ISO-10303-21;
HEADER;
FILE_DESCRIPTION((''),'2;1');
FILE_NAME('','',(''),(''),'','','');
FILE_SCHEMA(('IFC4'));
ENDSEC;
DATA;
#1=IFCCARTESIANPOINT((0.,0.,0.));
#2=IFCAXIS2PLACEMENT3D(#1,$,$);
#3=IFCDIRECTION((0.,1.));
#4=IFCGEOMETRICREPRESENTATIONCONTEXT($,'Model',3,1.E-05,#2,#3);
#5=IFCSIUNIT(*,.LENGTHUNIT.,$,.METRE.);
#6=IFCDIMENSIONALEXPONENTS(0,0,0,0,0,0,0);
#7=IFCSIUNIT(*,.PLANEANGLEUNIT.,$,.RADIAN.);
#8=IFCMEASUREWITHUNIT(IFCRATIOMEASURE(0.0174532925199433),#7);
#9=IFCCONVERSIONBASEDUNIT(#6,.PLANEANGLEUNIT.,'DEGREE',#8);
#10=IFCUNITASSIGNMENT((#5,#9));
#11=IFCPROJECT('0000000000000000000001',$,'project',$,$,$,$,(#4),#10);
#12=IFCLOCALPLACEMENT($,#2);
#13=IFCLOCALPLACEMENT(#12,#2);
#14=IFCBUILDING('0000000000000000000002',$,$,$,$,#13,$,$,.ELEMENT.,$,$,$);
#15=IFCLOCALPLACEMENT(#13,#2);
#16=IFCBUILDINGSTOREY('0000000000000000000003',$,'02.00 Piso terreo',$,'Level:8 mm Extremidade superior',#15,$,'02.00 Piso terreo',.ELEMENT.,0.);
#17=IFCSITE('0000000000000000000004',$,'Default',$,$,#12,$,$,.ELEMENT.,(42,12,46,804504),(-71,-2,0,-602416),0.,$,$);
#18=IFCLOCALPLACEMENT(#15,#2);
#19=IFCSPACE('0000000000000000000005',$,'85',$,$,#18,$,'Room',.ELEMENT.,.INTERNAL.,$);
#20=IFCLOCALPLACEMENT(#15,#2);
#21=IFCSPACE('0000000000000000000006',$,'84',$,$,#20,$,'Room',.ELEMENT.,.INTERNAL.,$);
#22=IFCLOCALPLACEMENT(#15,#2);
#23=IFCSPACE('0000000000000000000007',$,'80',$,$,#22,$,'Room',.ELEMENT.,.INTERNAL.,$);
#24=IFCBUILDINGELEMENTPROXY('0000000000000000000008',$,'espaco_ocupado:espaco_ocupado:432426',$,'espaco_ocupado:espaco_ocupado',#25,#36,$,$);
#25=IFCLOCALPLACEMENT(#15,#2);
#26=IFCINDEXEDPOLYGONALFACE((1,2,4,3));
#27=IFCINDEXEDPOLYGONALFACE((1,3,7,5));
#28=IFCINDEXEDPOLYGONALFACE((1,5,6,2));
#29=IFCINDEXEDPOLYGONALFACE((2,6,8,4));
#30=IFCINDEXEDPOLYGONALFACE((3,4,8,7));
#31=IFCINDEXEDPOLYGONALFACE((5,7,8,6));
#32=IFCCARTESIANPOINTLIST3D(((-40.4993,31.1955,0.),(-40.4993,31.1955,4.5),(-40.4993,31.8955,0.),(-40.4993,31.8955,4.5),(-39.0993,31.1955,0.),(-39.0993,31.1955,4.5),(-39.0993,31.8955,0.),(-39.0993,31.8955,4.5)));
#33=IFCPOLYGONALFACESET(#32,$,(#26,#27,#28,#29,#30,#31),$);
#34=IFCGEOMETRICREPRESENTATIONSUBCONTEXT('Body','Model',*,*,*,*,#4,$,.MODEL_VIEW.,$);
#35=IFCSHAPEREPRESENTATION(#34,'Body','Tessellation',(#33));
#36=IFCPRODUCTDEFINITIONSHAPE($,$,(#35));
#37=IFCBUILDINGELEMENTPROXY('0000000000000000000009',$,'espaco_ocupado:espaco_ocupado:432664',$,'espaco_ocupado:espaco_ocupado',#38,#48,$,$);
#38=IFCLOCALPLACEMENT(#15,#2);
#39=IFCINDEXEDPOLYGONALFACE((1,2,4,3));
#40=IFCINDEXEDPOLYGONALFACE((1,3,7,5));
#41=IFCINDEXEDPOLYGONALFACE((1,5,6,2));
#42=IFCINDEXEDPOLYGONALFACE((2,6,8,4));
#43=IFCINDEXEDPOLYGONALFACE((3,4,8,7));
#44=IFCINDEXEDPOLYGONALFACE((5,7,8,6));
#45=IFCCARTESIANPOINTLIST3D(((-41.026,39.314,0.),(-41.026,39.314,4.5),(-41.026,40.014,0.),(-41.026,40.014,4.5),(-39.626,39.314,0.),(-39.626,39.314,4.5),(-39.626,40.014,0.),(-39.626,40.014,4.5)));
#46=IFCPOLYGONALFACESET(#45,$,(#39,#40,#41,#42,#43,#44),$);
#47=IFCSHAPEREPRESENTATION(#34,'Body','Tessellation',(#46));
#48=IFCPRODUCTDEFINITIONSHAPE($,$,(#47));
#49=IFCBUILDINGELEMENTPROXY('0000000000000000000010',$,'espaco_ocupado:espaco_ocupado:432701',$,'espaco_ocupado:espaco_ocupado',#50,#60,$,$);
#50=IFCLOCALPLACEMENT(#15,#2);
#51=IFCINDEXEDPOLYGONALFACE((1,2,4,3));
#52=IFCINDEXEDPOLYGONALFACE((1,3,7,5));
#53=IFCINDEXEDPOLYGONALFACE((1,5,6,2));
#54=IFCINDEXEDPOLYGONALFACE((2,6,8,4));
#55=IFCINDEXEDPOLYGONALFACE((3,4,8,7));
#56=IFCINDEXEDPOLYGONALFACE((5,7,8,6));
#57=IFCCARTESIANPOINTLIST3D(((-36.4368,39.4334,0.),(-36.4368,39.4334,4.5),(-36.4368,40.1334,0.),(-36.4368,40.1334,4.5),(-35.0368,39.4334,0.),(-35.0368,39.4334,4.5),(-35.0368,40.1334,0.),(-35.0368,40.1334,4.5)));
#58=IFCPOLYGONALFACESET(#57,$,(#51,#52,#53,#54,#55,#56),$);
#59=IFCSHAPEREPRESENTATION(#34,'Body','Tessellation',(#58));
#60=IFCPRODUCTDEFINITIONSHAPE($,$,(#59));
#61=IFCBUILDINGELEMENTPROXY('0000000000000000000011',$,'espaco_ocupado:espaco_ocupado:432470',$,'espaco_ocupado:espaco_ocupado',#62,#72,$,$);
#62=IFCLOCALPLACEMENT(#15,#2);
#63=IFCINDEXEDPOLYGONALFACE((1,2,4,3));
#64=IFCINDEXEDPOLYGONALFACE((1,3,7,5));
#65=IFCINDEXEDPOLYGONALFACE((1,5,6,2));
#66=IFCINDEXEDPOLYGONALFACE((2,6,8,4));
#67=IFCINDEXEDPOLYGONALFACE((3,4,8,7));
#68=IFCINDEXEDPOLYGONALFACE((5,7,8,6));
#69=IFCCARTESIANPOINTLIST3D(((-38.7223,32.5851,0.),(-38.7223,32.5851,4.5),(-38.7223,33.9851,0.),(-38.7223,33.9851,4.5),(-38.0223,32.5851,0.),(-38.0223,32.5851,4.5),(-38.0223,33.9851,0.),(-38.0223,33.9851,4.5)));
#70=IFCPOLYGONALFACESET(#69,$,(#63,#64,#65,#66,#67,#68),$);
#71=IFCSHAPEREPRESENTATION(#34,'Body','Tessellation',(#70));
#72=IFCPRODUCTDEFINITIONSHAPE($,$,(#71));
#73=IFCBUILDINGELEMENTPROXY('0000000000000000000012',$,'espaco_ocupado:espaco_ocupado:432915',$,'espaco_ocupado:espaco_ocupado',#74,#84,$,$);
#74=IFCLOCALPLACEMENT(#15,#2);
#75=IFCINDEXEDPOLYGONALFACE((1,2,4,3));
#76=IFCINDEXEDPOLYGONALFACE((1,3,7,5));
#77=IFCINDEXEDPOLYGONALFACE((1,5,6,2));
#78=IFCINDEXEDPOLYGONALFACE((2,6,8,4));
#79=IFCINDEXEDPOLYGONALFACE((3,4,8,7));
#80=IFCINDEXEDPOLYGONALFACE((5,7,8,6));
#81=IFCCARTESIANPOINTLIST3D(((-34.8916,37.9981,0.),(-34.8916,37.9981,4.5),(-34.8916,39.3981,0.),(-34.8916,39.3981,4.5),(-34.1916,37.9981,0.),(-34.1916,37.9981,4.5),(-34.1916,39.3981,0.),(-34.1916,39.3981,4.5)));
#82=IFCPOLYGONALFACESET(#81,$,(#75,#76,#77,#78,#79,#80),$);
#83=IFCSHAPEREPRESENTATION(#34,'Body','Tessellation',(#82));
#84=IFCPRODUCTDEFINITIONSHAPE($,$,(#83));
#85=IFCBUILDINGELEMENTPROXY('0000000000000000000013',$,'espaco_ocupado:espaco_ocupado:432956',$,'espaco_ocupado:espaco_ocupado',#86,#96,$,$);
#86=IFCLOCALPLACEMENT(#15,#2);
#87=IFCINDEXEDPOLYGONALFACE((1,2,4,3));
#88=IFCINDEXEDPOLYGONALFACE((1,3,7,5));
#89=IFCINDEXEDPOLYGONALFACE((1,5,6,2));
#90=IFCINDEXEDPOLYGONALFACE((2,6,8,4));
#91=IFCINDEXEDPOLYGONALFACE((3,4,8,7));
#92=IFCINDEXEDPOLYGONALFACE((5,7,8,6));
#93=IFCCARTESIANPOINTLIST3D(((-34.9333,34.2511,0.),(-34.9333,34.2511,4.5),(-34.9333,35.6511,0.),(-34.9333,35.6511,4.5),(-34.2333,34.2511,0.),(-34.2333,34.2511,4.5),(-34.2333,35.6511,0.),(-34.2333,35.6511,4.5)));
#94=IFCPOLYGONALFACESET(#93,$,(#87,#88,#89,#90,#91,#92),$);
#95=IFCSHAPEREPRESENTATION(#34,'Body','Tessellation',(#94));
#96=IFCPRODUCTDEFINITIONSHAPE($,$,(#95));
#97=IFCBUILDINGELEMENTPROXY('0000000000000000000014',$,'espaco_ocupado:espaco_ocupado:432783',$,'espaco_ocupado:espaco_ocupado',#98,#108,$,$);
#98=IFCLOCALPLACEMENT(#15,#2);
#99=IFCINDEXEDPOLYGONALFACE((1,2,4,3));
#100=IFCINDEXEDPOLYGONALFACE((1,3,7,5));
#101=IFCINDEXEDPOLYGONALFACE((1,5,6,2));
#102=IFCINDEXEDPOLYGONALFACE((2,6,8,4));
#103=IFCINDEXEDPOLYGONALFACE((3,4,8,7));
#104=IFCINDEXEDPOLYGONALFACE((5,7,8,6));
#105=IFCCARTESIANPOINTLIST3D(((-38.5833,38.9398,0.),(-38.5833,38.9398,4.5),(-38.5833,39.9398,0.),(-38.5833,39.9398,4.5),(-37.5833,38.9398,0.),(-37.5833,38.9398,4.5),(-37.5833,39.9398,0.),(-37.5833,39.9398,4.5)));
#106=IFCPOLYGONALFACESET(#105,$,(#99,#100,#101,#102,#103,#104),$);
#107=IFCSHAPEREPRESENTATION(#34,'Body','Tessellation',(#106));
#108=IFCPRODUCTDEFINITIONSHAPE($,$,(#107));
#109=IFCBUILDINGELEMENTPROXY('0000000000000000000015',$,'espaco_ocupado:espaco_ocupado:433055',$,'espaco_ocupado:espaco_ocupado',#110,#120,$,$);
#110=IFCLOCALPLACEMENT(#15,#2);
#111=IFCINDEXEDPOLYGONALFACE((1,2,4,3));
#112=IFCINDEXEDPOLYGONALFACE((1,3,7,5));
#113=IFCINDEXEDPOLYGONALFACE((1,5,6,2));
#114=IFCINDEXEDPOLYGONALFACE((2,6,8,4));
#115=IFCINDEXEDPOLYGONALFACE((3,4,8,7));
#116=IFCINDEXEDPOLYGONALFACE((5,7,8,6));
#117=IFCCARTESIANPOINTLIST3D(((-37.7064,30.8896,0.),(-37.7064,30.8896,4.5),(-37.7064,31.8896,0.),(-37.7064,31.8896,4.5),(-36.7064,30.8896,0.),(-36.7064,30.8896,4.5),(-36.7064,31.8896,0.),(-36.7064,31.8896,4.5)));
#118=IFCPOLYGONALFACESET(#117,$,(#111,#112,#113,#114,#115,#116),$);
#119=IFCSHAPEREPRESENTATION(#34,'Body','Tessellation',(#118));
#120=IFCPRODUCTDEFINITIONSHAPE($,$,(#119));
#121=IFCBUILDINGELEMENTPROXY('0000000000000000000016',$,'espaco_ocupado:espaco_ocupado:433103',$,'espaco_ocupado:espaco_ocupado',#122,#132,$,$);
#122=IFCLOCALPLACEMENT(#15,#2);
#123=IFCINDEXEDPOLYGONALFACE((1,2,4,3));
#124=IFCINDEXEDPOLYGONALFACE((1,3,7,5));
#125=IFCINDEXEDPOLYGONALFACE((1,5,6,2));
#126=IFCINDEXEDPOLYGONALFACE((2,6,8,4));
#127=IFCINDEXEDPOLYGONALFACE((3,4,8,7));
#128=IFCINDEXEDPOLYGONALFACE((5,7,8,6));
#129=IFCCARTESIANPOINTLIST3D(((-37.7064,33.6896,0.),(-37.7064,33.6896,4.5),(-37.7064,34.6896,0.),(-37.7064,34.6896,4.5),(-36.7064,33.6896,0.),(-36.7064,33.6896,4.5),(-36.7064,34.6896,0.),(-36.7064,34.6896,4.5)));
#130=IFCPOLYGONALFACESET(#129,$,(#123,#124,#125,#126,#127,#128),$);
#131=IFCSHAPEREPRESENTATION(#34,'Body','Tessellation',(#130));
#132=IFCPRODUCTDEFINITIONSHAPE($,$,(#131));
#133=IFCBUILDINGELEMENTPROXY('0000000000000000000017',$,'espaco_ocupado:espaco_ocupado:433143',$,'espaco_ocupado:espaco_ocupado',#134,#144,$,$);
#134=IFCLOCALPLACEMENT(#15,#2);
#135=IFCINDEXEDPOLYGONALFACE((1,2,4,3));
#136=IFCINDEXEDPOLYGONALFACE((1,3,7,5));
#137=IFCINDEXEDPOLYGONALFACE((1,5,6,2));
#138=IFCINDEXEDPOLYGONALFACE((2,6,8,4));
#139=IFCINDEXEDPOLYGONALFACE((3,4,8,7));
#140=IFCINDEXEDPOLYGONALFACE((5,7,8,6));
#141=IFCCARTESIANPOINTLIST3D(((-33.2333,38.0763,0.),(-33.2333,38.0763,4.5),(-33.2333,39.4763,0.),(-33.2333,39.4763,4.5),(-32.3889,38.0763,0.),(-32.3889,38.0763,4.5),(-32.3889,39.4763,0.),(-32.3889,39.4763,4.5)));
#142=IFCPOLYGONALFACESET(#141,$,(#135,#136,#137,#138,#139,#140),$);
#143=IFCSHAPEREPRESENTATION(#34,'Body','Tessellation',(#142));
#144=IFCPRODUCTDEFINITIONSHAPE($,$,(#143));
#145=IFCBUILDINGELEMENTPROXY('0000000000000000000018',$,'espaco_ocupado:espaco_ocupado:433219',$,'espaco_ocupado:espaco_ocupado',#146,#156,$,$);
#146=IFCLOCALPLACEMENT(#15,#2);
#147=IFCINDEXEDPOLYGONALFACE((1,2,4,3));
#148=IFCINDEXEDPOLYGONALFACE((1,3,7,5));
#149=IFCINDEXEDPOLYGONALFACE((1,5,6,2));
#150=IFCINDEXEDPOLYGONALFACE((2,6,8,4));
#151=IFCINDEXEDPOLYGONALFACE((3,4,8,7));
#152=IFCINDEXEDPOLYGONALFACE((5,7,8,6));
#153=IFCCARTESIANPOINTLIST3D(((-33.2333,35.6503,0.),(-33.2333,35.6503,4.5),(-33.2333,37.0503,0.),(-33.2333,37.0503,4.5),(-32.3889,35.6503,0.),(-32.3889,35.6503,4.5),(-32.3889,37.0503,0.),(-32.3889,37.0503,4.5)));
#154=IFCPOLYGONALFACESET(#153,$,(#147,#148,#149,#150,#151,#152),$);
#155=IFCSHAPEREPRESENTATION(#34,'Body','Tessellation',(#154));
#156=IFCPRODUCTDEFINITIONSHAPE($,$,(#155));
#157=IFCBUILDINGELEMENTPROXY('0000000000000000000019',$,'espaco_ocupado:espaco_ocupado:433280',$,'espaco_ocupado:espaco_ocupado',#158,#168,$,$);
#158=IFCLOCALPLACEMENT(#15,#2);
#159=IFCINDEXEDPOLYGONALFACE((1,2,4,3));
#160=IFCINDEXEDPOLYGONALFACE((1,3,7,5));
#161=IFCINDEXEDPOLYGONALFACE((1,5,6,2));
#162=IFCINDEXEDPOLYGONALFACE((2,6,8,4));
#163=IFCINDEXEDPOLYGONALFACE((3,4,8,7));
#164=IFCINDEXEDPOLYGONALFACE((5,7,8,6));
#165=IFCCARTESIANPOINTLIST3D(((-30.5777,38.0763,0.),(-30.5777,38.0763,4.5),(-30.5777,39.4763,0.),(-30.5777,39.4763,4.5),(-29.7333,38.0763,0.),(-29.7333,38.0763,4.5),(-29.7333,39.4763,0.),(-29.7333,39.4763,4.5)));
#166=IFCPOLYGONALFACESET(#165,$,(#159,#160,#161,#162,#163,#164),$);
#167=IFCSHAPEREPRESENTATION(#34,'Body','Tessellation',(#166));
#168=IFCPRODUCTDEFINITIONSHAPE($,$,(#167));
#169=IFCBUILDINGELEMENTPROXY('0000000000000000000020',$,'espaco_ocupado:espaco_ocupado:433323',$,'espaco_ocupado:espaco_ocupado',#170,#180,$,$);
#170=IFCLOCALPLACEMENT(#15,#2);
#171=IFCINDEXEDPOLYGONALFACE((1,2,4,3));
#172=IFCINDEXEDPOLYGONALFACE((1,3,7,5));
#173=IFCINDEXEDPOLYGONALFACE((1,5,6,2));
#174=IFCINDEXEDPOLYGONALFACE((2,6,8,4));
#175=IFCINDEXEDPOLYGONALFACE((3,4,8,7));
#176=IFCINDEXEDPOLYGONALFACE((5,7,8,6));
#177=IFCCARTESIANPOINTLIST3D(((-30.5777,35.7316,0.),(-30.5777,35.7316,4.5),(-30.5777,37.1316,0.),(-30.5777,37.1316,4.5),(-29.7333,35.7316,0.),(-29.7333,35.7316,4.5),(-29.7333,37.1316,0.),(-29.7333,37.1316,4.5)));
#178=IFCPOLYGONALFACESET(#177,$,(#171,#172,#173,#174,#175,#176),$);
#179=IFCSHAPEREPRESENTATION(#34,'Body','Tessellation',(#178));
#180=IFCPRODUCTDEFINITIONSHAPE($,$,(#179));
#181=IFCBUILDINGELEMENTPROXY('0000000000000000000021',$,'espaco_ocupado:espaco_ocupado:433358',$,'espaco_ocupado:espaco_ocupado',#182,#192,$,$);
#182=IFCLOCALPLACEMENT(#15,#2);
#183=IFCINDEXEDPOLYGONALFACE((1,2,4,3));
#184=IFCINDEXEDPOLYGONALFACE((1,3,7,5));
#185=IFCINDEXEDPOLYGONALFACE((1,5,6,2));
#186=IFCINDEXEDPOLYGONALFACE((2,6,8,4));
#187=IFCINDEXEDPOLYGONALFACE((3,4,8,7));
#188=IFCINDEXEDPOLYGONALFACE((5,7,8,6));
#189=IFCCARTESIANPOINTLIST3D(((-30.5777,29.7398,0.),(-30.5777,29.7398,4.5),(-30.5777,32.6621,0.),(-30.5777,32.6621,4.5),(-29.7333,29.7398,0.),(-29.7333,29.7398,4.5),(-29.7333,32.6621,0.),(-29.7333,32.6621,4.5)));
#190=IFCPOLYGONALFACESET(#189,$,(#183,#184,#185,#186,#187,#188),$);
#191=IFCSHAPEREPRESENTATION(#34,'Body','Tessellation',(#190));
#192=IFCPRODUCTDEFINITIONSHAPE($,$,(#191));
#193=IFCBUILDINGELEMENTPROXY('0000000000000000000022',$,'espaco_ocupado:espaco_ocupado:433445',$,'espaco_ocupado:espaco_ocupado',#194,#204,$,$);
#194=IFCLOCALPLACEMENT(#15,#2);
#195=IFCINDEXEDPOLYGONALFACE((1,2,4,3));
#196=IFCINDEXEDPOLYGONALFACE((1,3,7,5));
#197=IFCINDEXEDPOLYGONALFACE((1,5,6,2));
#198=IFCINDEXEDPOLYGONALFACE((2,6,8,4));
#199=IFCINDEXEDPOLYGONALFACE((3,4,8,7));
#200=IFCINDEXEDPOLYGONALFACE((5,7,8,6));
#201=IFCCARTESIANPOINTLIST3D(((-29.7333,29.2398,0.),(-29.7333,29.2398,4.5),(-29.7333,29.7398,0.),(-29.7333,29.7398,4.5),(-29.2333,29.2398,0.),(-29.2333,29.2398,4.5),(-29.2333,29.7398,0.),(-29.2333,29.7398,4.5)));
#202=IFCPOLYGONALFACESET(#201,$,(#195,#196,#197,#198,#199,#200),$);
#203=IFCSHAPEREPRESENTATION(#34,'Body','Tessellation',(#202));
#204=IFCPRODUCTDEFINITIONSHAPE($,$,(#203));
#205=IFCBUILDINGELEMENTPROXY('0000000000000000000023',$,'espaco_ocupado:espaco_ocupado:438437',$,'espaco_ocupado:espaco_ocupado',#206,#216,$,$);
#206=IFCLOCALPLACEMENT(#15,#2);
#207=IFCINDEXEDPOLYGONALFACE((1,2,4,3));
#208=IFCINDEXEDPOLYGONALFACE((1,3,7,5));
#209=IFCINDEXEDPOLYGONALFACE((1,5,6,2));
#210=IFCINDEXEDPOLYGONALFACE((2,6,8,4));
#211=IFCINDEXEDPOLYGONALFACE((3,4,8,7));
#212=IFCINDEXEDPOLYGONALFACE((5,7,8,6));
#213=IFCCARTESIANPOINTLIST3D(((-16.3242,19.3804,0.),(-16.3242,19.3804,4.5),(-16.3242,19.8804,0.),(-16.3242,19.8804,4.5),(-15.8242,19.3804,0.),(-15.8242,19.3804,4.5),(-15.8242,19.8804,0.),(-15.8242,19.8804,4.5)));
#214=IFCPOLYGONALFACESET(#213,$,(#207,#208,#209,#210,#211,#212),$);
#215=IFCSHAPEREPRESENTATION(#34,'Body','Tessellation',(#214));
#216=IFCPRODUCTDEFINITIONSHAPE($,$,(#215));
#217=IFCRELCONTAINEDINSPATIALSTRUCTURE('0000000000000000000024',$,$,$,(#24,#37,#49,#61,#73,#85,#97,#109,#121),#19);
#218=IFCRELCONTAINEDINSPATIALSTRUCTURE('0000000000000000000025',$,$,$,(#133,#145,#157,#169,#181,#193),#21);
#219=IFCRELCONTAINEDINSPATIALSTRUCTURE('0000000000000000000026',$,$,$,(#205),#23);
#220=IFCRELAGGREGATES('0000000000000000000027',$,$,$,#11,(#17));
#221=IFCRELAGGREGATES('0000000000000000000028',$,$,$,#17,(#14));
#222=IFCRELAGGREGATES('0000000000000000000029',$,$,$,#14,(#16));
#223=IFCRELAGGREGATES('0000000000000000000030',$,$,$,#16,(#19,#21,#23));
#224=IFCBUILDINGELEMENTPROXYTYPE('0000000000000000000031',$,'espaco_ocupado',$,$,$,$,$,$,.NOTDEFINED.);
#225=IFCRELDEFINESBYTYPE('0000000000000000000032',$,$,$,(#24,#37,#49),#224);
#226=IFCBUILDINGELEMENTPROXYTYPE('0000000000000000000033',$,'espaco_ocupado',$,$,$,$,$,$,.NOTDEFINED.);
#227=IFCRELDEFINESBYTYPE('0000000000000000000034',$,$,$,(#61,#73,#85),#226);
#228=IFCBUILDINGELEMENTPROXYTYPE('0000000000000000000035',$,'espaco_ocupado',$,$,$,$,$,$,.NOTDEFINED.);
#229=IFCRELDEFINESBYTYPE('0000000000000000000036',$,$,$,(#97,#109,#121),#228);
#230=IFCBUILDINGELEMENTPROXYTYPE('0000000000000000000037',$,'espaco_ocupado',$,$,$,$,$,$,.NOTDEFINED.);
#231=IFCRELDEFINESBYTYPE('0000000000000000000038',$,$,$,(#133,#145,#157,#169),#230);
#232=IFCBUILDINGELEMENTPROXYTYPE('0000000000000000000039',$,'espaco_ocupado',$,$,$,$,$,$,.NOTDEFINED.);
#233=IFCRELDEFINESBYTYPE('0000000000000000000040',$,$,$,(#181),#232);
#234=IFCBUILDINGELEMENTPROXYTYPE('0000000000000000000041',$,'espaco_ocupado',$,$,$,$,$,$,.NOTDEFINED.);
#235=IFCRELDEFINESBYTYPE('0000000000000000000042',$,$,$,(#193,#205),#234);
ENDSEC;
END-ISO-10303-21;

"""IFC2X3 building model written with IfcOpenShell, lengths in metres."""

from ifc_helpers import new_model, entity, si_unit, converted_unit, direction, frame, origin, origin_2d_with_axis, place, context, subcontext, project, spatial, rectangle, extrude, source, transform, mapped, type_object, type_shapes, element, save


model = new_model("IFC2X3")

# Units and contexts
model_context = context("Model", 3, precision=1e-05, world=origin(), true_north=direction((0.0, 1.0)))
body_context = subcontext(model_context, "Body", "Model", "MODEL_VIEW")
ifc_project = project(units=[si_unit("LENGTHUNIT", "METRE"), converted_unit("PLANEANGLEUNIT", "DEGREE", entity("IfcRatioMeasure", 0.0174532925199433), si_unit("PLANEANGLEUNIT", "RADIAN"), dimensions=[0, 0, 0, 0, 0, 0, 0])], contexts=[model_context])

# Site, building, storey, space
site_placement = place(None, origin())
site = spatial("IfcSite", under=ifc_project, at=site_placement, Name="Default", CompositionType="ELEMENT", RefLatitude=(42, 12, 46, 804504), RefLongitude=(-71, -2, 0, -602416), RefElevation=0.0)
building_placement = place(site_placement, origin())
building = spatial("IfcBuilding", under=site, at=building_placement, CompositionType="ELEMENT")
storey_placement = place(building_placement, origin())
storey = spatial("IfcBuildingStorey", under=building, at=storey_placement, Name="02.00 Piso terreo", ObjectType="Level:8 mm Extremidade superior", LongName="02.00 Piso terreo", CompositionType="ELEMENT", Elevation=0.0)
space_1_placement = place(storey_placement, origin())
space_1 = spatial("IfcSpace", under=storey, at=space_1_placement, Name="85", LongName="Room", CompositionType="ELEMENT", InteriorOrExteriorSpace="INTERNAL")

# Building element proxies
building_element_proxy_type_1 = type_object("IfcBuildingElementProxyType", Name="espaco_ocupado", PredefinedType="NOTDEFINED")
shared_shape_1 = source(origin(), body_context, "Body", "SweptSolid", [
    extrude(rectangle(XDim=1.4, YDim=0.7, at=origin_2d_with_axis()), frame((0.0, 0.0, 0.0), z_axis=(0.0, 0.0, 1.0), x_axis=(-1.0, 0.0, 0.0)), (0.0, 0.0, 1.0), 4.5),
])
type_shapes(building_element_proxy_type_1, [shared_shape_1])
for number, where, name in (
    (1, (-39.7993, 31.5455, 0.0), "espaco_ocupado:espaco_ocupado:432426"),
    (2, (-40.326, 39.664, 0.0), "espaco_ocupado:espaco_ocupado:432664"),
    (3, (-35.7368, 39.7834, 0.0), "espaco_ocupado:espaco_ocupado:432701"),
):
    element("IfcBuildingElementProxy", number, at=place(space_1_placement, frame(where)), inside=space_1, type_object=building_element_proxy_type_1, Name=name, ObjectType="espaco_ocupado:espaco_ocupado", context=body_context, shape_type="MappedRepresentation", body=[
        mapped(shared_shape_1, transform((0.0, 0.0, 0.0), scale=1.0)),
    ])
building_element_proxy_type_2 = type_object("IfcBuildingElementProxyType", Name="espaco_ocupado", PredefinedType="NOTDEFINED")
shared_shape_2 = source(origin(), body_context, "Body", "SweptSolid", [
    extrude(rectangle(XDim=0.7, YDim=1.4, at=origin_2d_with_axis()), frame((0.0, 0.0, 0.0), z_axis=(0.0, 0.0, 1.0), x_axis=(-1.0, 0.0, 0.0)), (0.0, 0.0, 1.0), 4.5),
])
type_shapes(building_element_proxy_type_2, [shared_shape_2])
for number, where, name in (
    (4, (-38.3723, 33.2851, 0.0), "espaco_ocupado:espaco_ocupado:432470"),
    (5, (-34.5416, 38.6981, 0.0), "espaco_ocupado:espaco_ocupado:432915"),
    (6, (-34.5833, 34.9511, 0.0), "espaco_ocupado:espaco_ocupado:432956"),
):
    element("IfcBuildingElementProxy", number, at=place(space_1_placement, frame(where)), inside=space_1, type_object=building_element_proxy_type_2, Name=name, ObjectType="espaco_ocupado:espaco_ocupado", context=body_context, shape_type="MappedRepresentation", body=[
        mapped(shared_shape_2, transform((0.0, 0.0, 0.0), scale=1.0)),
    ])
building_element_proxy_type_3 = type_object("IfcBuildingElementProxyType", Name="espaco_ocupado", PredefinedType="NOTDEFINED")
shared_shape_3 = source(origin(), body_context, "Body", "SweptSolid", [
    extrude(rectangle(XDim=1.0, YDim=1.0, at=origin_2d_with_axis()), frame((0.0, 0.0, 0.0), z_axis=(0.0, 0.0, 1.0), x_axis=(-1.0, 0.0, 0.0)), (0.0, 0.0, 1.0), 4.5),
])
type_shapes(building_element_proxy_type_3, [shared_shape_3])
for number, where, name in (
    (7, (-38.0833, 39.4398, 0.0), "espaco_ocupado:espaco_ocupado:432783"),
    (8, (-37.2064, 31.3896, 0.0), "espaco_ocupado:espaco_ocupado:433055"),
    (9, (-37.2064, 34.1896, 0.0), "espaco_ocupado:espaco_ocupado:433103"),
):
    element("IfcBuildingElementProxy", number, at=place(space_1_placement, frame(where)), inside=space_1, type_object=building_element_proxy_type_3, Name=name, ObjectType="espaco_ocupado:espaco_ocupado", context=body_context, shape_type="MappedRepresentation", body=[
        mapped(shared_shape_3, transform((0.0, 0.0, 0.0), scale=1.0)),
    ])

# Shared definitions
space_2_placement = place(storey_placement, origin())
space_2 = spatial("IfcSpace", under=storey, at=space_2_placement, Name="84", LongName="Room", CompositionType="ELEMENT", InteriorOrExteriorSpace="INTERNAL")

# Building element proxies
building_element_proxy_type_4 = type_object("IfcBuildingElementProxyType", Name="espaco_ocupado", PredefinedType="NOTDEFINED")
shared_shape_4 = source(origin(), body_context, "Body", "SweptSolid", [
    extrude(rectangle(XDim=0.8444, YDim=1.4, at=origin_2d_with_axis()), frame((0.0, 0.0, 0.0), z_axis=(0.0, 0.0, 1.0), x_axis=(-1.0, 0.0, 0.0)), (0.0, 0.0, 1.0), 4.5),
])
type_shapes(building_element_proxy_type_4, [shared_shape_4])
for number, where, name in (
    (10, (-32.8111, 38.7763, 0.0), "espaco_ocupado:espaco_ocupado:433143"),
    (11, (-32.8111, 36.3503, 0.0), "espaco_ocupado:espaco_ocupado:433219"),
    (12, (-30.1555, 38.7763, 0.0), "espaco_ocupado:espaco_ocupado:433280"),
    (13, (-30.1555, 36.4316, 0.0), "espaco_ocupado:espaco_ocupado:433323"),
):
    element("IfcBuildingElementProxy", number, at=place(space_2_placement, frame(where)), inside=space_2, type_object=building_element_proxy_type_4, Name=name, ObjectType="espaco_ocupado:espaco_ocupado", context=body_context, shape_type="MappedRepresentation", body=[
        mapped(shared_shape_4, transform((0.0, 0.0, 0.0), scale=1.0)),
    ])
building_element_proxy_type_5 = type_object("IfcBuildingElementProxyType", Name="espaco_ocupado", PredefinedType="NOTDEFINED")
shared_shape_5 = source(origin(), body_context, "Body", "SweptSolid", [
    extrude(rectangle(XDim=0.8444, YDim=2.9222, at=origin_2d_with_axis()), frame((0.0, 0.0, 0.0), z_axis=(0.0, 0.0, 1.0), x_axis=(-1.0, 0.0, 0.0)), (0.0, 0.0, 1.0), 4.5),
])
type_shapes(building_element_proxy_type_5, [shared_shape_5])
proxy_1_placement = place(space_2_placement, frame((-30.1555, 31.201, 0.0)))
element("IfcBuildingElementProxy", 14, at=proxy_1_placement, inside=space_2, type_object=building_element_proxy_type_5, Name="espaco_ocupado:espaco_ocupado:433358", ObjectType="espaco_ocupado:espaco_ocupado", context=body_context, shape_type="MappedRepresentation", body=[
    mapped(shared_shape_5, transform((0.0, 0.0, 0.0), scale=1.0)),
])
building_element_proxy_type_6 = type_object("IfcBuildingElementProxyType", Name="espaco_ocupado", PredefinedType="NOTDEFINED")
shared_shape_6 = source(origin(), body_context, "Body", "SweptSolid", [
    extrude(rectangle(XDim=0.5, YDim=0.5, at=origin_2d_with_axis()), frame((0.0, 0.0, 0.0), z_axis=(0.0, 0.0, 1.0), x_axis=(-1.0, 0.0, 0.0)), (0.0, 0.0, 1.0), 4.5),
])
type_shapes(building_element_proxy_type_6, [shared_shape_6])
proxy_2_placement = place(space_2_placement, frame((-29.4833, 29.4898, 0.0)))
element("IfcBuildingElementProxy", 15, at=proxy_2_placement, inside=space_2, type_object=building_element_proxy_type_6, Name="espaco_ocupado:espaco_ocupado:433445", ObjectType="espaco_ocupado:espaco_ocupado", context=body_context, shape_type="MappedRepresentation", body=[
    mapped(shared_shape_6, transform((0.0, 0.0, 0.0), scale=1.0)),
])

# Shared definitions
space_3_placement = place(storey_placement, origin())
space_3 = spatial("IfcSpace", under=storey, at=space_3_placement, Name="80", LongName="Room", CompositionType="ELEMENT", InteriorOrExteriorSpace="INTERNAL")

# Building element proxy
proxy_3_placement = place(space_3_placement, frame((-16.0742, 19.6304, 0.0)))
element("IfcBuildingElementProxy", 16, at=proxy_3_placement, inside=space_3, type_object=building_element_proxy_type_6, Name="espaco_ocupado:espaco_ocupado:438437", ObjectType="espaco_ocupado:espaco_ocupado", context=body_context, shape_type="MappedRepresentation", body=[
    mapped(shared_shape_6, transform((0.0, 0.0, 0.0), scale=1.0)),
])

save(model, "model.ifc")
